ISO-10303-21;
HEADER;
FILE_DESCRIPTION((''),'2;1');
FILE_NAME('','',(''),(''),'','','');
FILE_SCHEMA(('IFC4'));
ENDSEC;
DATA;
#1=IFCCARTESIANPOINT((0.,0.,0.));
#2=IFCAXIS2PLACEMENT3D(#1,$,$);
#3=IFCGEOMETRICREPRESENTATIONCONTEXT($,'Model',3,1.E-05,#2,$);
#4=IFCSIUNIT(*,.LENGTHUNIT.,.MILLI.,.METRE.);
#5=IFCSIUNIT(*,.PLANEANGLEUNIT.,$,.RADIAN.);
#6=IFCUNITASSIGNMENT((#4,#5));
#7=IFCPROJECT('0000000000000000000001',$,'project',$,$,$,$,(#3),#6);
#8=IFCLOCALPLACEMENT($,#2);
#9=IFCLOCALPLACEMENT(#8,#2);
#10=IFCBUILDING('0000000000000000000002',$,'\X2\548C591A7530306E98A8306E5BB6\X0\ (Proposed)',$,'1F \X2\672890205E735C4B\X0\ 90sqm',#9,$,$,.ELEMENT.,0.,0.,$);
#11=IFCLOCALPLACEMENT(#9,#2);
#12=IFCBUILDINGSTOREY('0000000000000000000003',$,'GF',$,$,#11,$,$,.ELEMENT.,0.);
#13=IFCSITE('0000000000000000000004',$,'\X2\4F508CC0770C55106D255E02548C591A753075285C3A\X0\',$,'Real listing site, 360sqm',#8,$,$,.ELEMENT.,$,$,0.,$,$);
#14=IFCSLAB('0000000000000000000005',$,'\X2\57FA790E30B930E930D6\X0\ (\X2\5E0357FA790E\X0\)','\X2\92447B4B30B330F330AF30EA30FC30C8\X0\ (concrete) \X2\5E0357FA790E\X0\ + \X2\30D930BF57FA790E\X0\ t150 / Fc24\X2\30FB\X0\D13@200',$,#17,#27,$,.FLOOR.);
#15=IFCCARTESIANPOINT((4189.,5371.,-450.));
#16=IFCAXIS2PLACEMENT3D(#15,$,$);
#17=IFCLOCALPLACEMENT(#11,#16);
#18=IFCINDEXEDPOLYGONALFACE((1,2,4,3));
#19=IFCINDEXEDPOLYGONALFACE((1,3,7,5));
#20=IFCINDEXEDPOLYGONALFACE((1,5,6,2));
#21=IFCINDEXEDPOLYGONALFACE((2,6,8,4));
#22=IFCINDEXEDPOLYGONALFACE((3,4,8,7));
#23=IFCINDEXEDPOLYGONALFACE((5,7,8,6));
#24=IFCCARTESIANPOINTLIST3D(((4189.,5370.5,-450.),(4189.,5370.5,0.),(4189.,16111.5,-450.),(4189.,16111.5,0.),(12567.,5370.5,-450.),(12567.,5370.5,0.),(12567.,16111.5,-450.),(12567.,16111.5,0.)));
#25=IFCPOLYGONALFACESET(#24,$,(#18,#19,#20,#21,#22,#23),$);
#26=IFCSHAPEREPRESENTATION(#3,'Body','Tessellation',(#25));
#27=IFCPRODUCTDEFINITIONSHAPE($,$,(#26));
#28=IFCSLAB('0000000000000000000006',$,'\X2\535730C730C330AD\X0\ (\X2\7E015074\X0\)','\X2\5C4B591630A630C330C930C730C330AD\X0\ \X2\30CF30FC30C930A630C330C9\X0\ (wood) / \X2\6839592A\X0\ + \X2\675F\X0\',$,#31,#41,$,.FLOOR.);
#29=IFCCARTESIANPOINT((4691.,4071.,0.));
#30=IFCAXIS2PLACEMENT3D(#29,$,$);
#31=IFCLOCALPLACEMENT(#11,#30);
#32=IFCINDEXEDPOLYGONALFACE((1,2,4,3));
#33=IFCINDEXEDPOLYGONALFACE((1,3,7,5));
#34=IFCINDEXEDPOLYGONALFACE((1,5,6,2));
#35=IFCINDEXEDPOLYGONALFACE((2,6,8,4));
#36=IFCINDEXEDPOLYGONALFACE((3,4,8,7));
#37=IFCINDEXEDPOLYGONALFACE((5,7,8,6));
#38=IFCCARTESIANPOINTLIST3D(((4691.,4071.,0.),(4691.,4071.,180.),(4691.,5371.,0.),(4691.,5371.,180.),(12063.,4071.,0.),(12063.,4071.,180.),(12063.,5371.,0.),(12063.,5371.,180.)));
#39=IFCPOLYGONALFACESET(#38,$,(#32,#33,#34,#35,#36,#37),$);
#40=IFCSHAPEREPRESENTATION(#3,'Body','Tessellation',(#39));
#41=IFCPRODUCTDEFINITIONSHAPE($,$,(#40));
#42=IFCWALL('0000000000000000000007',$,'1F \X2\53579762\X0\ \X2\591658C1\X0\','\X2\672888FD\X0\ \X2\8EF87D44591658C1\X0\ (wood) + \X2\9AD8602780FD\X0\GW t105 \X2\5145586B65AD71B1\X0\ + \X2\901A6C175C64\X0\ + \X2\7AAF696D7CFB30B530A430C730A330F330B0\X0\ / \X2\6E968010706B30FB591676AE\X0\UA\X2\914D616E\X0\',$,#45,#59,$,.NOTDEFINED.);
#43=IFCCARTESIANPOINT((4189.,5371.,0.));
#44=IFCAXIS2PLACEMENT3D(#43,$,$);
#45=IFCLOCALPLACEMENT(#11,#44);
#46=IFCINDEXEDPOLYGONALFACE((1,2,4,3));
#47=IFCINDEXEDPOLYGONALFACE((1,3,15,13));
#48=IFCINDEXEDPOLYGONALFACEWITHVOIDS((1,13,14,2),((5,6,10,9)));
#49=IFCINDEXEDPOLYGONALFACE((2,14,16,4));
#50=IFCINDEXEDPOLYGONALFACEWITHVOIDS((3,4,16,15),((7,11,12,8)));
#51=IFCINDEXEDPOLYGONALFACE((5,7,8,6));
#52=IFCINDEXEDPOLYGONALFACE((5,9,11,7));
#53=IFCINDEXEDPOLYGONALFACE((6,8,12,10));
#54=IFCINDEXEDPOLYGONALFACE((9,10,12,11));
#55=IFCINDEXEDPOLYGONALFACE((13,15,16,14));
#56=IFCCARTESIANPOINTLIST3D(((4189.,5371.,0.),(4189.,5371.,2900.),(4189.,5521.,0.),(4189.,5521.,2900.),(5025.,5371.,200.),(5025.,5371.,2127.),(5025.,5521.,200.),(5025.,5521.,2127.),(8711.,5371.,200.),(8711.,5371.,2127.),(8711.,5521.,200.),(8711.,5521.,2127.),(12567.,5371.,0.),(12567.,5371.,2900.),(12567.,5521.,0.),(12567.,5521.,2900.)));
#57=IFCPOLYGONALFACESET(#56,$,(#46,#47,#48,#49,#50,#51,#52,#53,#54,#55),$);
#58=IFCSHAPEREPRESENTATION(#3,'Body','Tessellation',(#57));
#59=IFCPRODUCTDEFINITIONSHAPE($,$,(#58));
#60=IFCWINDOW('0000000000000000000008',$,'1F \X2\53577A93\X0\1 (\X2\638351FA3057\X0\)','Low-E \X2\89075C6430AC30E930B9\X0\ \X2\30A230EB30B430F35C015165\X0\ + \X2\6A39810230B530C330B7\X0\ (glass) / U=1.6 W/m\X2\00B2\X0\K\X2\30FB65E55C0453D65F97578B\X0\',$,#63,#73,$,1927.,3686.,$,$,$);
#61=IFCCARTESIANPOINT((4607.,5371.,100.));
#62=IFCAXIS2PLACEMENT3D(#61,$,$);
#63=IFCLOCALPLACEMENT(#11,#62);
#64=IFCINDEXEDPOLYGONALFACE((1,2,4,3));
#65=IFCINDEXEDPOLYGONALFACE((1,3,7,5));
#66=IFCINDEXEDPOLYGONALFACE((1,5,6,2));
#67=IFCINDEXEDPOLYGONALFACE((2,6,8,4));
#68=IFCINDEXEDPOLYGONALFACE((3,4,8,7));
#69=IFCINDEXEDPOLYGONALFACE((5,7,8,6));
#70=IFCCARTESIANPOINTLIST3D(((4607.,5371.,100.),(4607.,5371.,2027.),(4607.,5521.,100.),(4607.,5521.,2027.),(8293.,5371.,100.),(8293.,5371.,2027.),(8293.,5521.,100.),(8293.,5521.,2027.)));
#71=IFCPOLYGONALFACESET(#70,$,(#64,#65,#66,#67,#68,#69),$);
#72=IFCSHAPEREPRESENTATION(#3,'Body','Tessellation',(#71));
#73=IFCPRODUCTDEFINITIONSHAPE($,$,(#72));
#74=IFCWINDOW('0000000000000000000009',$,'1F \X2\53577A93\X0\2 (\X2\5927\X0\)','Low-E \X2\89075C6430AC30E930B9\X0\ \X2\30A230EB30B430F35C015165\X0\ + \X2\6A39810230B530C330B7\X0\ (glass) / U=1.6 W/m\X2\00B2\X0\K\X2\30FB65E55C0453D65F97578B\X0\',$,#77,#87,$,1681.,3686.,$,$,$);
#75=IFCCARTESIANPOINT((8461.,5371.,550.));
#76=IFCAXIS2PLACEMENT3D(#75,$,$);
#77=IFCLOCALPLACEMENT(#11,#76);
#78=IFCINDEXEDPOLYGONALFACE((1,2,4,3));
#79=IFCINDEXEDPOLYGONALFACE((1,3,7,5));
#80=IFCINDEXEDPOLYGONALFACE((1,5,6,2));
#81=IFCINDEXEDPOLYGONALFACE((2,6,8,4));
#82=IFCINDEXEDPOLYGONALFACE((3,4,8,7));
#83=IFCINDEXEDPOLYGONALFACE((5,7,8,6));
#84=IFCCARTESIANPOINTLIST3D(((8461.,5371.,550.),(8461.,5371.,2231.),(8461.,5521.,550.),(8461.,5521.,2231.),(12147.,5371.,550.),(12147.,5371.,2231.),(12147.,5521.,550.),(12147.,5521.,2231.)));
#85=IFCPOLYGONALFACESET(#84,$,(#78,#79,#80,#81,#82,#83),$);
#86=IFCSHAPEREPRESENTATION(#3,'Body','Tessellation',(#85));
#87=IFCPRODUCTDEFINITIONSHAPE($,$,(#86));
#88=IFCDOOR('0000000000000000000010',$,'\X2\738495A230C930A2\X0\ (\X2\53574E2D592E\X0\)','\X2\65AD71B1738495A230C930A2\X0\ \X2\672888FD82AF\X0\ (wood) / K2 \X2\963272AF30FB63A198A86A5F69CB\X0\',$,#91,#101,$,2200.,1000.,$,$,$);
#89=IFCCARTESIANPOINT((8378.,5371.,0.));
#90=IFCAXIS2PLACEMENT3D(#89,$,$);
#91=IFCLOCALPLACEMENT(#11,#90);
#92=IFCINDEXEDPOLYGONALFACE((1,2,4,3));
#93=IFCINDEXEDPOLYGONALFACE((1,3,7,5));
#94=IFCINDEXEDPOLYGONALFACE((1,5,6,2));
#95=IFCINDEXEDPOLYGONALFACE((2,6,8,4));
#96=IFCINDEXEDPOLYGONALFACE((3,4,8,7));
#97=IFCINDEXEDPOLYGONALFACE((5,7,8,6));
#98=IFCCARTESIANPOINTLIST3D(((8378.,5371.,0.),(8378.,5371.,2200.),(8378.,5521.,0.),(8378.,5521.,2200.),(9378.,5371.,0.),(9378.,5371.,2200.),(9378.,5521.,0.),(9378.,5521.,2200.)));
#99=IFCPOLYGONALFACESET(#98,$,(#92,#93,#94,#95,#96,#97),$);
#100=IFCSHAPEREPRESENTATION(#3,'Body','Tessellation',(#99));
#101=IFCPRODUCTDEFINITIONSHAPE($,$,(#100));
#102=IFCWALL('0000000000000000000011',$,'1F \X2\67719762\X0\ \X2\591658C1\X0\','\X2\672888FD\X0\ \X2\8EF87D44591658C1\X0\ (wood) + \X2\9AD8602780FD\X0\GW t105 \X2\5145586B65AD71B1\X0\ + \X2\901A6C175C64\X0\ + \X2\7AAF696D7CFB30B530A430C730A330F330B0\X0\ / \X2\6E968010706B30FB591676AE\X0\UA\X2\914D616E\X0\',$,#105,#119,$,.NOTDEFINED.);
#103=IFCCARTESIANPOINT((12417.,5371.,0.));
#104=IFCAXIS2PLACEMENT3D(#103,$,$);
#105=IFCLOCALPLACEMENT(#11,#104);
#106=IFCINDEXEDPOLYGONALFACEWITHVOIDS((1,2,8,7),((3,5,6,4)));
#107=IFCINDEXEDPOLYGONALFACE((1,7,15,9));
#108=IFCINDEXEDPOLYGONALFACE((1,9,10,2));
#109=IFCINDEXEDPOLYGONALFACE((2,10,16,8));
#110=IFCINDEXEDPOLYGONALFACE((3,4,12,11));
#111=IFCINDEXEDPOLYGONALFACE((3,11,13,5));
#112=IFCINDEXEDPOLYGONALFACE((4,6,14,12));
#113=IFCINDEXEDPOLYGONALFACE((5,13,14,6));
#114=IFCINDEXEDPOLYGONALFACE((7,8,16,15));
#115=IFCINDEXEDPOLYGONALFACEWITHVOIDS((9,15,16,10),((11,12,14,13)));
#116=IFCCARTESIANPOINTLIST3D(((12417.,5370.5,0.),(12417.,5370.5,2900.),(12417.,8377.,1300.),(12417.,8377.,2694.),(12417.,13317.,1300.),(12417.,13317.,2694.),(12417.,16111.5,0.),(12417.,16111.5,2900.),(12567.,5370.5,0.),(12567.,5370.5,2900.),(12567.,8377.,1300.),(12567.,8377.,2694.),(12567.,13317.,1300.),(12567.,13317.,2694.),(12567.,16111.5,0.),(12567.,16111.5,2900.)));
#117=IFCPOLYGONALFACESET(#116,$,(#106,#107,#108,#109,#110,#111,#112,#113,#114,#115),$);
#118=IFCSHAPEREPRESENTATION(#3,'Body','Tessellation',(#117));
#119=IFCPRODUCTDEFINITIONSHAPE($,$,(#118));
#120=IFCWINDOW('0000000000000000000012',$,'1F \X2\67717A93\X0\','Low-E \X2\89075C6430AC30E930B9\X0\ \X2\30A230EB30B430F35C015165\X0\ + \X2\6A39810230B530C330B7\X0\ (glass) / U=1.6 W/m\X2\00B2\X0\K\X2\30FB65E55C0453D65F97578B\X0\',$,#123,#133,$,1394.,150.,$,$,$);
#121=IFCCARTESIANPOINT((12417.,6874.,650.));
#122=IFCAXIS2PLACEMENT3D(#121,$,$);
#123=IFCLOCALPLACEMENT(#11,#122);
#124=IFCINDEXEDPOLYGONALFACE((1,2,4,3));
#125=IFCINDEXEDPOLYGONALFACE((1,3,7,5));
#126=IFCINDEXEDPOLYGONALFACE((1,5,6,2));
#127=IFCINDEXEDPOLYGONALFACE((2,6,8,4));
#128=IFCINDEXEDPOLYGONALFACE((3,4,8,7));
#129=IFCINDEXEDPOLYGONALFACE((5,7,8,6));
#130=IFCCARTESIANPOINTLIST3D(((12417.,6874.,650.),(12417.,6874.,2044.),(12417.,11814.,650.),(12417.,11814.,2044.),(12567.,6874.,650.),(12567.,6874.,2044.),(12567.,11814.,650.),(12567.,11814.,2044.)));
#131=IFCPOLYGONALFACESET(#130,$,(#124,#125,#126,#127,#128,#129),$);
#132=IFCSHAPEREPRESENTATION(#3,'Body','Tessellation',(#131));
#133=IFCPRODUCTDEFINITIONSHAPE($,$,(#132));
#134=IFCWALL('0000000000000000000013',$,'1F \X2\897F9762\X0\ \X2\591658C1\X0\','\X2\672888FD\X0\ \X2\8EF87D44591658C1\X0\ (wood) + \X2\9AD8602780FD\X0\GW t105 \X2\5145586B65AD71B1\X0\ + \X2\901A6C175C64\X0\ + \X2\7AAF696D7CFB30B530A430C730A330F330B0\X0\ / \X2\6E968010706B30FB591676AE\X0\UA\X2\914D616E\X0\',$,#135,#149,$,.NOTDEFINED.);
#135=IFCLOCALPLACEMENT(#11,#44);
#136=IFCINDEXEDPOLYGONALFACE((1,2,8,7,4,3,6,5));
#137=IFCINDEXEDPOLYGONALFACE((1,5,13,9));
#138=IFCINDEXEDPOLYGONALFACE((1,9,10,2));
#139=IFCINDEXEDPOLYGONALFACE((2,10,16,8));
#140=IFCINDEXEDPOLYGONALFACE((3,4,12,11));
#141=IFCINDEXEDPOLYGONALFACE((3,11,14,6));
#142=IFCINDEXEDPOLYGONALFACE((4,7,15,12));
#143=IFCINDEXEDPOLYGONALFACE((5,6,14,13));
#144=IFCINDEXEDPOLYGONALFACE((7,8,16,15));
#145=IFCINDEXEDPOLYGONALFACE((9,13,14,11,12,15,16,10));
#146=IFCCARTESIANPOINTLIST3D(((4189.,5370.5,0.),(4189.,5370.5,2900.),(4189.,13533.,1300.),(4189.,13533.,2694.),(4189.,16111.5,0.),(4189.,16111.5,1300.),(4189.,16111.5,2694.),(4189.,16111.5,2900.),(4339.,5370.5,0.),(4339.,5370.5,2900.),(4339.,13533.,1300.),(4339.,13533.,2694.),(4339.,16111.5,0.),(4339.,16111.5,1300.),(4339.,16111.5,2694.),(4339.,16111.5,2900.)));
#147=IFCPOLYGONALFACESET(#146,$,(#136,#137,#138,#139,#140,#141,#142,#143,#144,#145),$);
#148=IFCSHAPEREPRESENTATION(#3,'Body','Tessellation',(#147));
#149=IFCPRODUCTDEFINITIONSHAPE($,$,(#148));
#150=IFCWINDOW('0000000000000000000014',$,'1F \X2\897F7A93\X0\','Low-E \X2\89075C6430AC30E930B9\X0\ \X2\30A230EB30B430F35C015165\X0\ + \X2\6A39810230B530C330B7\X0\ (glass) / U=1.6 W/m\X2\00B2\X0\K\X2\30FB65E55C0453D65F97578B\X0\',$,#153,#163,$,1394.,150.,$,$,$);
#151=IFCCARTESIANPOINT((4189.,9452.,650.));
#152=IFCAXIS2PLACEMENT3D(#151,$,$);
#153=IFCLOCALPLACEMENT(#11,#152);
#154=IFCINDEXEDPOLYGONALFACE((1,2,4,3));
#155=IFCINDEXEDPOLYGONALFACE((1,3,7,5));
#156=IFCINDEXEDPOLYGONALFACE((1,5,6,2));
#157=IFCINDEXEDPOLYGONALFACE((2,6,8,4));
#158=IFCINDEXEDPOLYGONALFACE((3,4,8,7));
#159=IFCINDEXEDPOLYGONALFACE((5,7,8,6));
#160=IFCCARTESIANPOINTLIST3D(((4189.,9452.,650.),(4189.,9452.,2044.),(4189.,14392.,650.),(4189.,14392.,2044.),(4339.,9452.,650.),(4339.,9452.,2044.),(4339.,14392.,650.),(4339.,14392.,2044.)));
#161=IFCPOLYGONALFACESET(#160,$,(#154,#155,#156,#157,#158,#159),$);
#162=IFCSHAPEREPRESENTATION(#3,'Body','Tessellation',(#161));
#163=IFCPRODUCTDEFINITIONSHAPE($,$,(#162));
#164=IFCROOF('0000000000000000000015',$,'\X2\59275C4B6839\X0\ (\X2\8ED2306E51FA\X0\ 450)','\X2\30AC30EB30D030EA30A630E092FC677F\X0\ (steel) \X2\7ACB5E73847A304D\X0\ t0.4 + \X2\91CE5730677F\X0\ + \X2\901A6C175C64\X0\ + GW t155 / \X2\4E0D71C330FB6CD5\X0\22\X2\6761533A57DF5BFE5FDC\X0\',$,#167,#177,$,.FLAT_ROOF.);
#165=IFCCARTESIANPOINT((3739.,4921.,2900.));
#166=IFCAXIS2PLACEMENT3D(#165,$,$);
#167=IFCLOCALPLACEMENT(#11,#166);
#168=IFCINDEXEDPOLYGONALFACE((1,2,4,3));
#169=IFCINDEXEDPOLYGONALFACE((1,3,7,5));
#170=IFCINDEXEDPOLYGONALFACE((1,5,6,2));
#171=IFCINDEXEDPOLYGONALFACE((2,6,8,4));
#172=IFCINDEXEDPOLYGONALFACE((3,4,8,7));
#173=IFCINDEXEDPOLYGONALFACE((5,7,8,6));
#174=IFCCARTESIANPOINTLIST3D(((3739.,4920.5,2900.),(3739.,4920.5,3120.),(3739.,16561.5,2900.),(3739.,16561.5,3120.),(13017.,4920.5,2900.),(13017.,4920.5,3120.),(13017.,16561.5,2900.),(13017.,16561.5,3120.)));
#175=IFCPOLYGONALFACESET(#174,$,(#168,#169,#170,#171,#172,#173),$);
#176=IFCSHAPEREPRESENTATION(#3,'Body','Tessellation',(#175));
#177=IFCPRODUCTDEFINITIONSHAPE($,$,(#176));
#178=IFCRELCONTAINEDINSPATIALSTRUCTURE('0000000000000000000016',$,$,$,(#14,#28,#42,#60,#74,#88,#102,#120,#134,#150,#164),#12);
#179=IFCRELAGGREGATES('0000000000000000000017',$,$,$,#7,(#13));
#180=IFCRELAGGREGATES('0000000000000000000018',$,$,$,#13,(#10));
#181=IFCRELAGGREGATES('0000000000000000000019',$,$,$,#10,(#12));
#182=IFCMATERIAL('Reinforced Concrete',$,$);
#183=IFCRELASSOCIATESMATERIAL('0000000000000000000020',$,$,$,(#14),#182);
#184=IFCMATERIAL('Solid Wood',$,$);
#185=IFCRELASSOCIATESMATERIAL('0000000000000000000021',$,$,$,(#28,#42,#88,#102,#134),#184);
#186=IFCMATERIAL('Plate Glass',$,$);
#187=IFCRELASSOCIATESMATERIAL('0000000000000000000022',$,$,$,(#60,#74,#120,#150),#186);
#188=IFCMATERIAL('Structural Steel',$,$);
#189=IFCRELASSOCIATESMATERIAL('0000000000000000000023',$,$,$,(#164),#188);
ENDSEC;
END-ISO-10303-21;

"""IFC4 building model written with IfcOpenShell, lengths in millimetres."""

from ifc_helpers import new_model, si_unit, frame, frame_2d, origin, place, context, project, spatial, rectangle, extrude, material, element, fill, save


model = new_model("IFC4")

# Units and contexts
model_context = context("Model", 3, precision=1e-05, world=origin())
ifc_project = project(units=[si_unit("LENGTHUNIT", "METRE", prefix="MILLI"), si_unit("PLANEANGLEUNIT", "RADIAN")], contexts=[model_context])

# Site, building, storey
site_placement = place(None, origin())
site = spatial("IfcSite", under=ifc_project, at=site_placement, Name="佐賀県唐津市和多田用尺", ObjectType="Real listing site, 360sqm", CompositionType="ELEMENT", RefElevation=0.0)
building_placement = place(site_placement, origin())
building = spatial("IfcBuilding", under=site, at=building_placement, Name="和多田の風の家 (Proposed)", ObjectType="1F 木造平屋 90sqm", CompositionType="ELEMENT", ElevationOfRefHeight=0.0, ElevationOfTerrain=0.0)
storey_placement = place(building_placement, origin())
storey = spatial("IfcBuildingStorey", under=building, at=storey_placement, Name="GF", CompositionType="ELEMENT", Elevation=0.0)

# Slabs
ifc_material_1 = material(Name="Reinforced Concrete")
slab_1_placement = place(storey_placement, frame((4189.0, 5371.0, -450.0)))
element("IfcSlab", 1, at=slab_1_placement, inside=storey, material=ifc_material_1, Name="基礎スラブ (布基礎)", Description="鉄筋コンクリート (concrete) 布基礎 + ベタ基礎 t150 / Fc24・D13@200", PredefinedType="FLOOR", context=model_context, shape_type="SweptSolid", body=[
    extrude(rectangle(XDim=8378.0, YDim=10741.0, at=frame_2d((4189.0, 5370.0))), frame((4189.0, 5371.0, -450.0)), (0.0, 0.0, 1.0), 450.0),
])
ifc_material_2 = material(Name="Solid Wood")
slab_2_placement = place(storey_placement, frame((4691.0, 4071.0, 0.0)))
element("IfcSlab", 2, at=slab_2_placement, inside=storey, material=ifc_material_2, Name="南デッキ (縁側)", Description="屋外ウッドデッキ ハードウッド (wood) / 根太 + 束", PredefinedType="FLOOR", context=model_context, shape_type="SweptSolid", body=[
    extrude(rectangle(XDim=7372.0, YDim=1300.0, at=frame_2d((3686.0, 650.0))), frame((4691.0, 4071.0, 0.0)), (0.0, 0.0, 1.0), 180.0),
])

# Wall, openings, windows, door
wall_1_placement = place(storey_placement, frame((4189.0, 5371.0, 0.0)))
wall_1 = element("IfcWall", 3, at=wall_1_placement, inside=storey, material=ifc_material_2, Name="1F 南面 外壁", Description="木製 軸組外壁 (wood) + 高性能GW t105 充填断熱 + 通気層 + 窯業系サイディング / 準耐火・外皮UA配慮", PredefinedType="NOTDEFINED", context=model_context, shape_type="SweptSolid", body=[
    extrude(rectangle(XDim=8378.0, YDim=150.0, at=frame_2d((4189.0, 75.0))), frame((4189.0, 5371.0, 0.0)), (0.0, 0.0, 1.0), 2900.0),
])
opening_1_placement = place(storey_placement, frame((4607.0, 5371.0, 100.0)))
opening_1 = element("IfcOpeningElement", 4, at=opening_1_placement, cuts=wall_1, PredefinedType="NOTDEFINED", context=model_context, shape_type="SweptSolid", body=[
    extrude(rectangle(XDim=3686.0, YDim=150.0, at=frame_2d((1843.0, 75.0))), frame((4607.0, 5371.0, 100.0)), (0.0, 0.0, 1.0), 1927.0),
])
opening_2_placement = place(storey_placement, frame((8461.0, 5371.0, 550.0)))
opening_2 = element("IfcOpeningElement", 5, at=opening_2_placement, cuts=wall_1, PredefinedType="NOTDEFINED", context=model_context, shape_type="SweptSolid", body=[
    extrude(rectangle(XDim=3686.0, YDim=150.0, at=frame_2d((1843.0, 75.0))), frame((8461.0, 5371.0, 550.0)), (0.0, 0.0, 1.0), 1681.0),
])
opening_3_placement = place(storey_placement, frame((8378.0, 5371.0, 0.0)))
opening_3 = element("IfcOpeningElement", 6, at=opening_3_placement, cuts=wall_1, PredefinedType="NOTDEFINED", context=model_context, shape_type="SweptSolid", body=[
    extrude(rectangle(XDim=1000.0, YDim=150.0, at=frame_2d((500.0, 75.0))), frame((8378.0, 5371.0, 0.0)), (0.0, 0.0, 1.0), 2200.0),
])
ifc_material_3 = material(Name="Plate Glass")
window_1_placement = place(storey_placement, frame((4607.0, 5371.0, 100.0)))
window_1 = element("IfcWindow", 7, at=window_1_placement, inside=storey, material=ifc_material_3, Name="1F 南窓1 (掃出し)", Description="Low-E 複層ガラス アルゴン封入 + 樹脂サッシ (glass) / U=1.6 W/m²K・日射取得型", OverallHeight=1927.0, OverallWidth=3686.0, context=model_context, shape_type="SweptSolid", body=[
    extrude(rectangle(XDim=3686.0, YDim=150.0, at=frame_2d((1843.0, 75.0))), frame((4607.0, 5371.0, 100.0)), (0.0, 0.0, 1.0), 1927.0),
])
fill(opening_1, window_1)
window_2_placement = place(storey_placement, frame((8461.0, 5371.0, 550.0)))
window_2 = element("IfcWindow", 8, at=window_2_placement, inside=storey, material=ifc_material_3, Name="1F 南窓2 (大)", Description="Low-E 複層ガラス アルゴン封入 + 樹脂サッシ (glass) / U=1.6 W/m²K・日射取得型", OverallHeight=1681.0, OverallWidth=3686.0, context=model_context, shape_type="SweptSolid", body=[
    extrude(rectangle(XDim=3686.0, YDim=150.0, at=frame_2d((1843.0, 75.0))), frame((8461.0, 5371.0, 550.0)), (0.0, 0.0, 1.0), 1681.0),
])
fill(opening_2, window_2)
door_placement = place(storey_placement, frame((8378.0, 5371.0, 0.0)))
door = element("IfcDoor", 9, at=door_placement, inside=storey, material=ifc_material_2, Name="玄関ドア (南中央)", Description="断熱玄関ドア 木製芯 (wood) / K2 防犯・採風機構", OverallHeight=2200.0, OverallWidth=1000.0, context=model_context, shape_type="SweptSolid", body=[
    extrude(rectangle(XDim=1000.0, YDim=150.0, at=frame_2d((500.0, 75.0))), frame((8378.0, 5371.0, 0.0)), (0.0, 0.0, 1.0), 2200.0),
])
fill(opening_3, door)

# Walls, openings, windows
wall_2_placement = place(storey_placement, frame((12417.0, 5371.0, 0.0)))
wall_2 = element("IfcWall", 10, at=wall_2_placement, inside=storey, material=ifc_material_2, Name="1F 東面 外壁", Description="木製 軸組外壁 (wood) + 高性能GW t105 充填断熱 + 通気層 + 窯業系サイディング / 準耐火・外皮UA配慮", PredefinedType="NOTDEFINED", context=model_context, shape_type="SweptSolid", body=[
    extrude(rectangle(XDim=150.0, YDim=10741.0, at=frame_2d((75.0, 5370.0))), frame((12417.0, 5371.0, 0.0)), (0.0, 0.0, 1.0), 2900.0),
])
opening_4_placement = place(storey_placement, frame((12417.0, 6874.0, 650.0)))
opening_4 = element("IfcOpeningElement", 11, at=opening_4_placement, cuts=wall_2, PredefinedType="NOTDEFINED", context=model_context, shape_type="SweptSolid", body=[
    extrude(rectangle(XDim=150.0, YDim=4940.0, at=frame_2d((75.0, 2470.0))), frame((12417.0, 6874.0, 650.0)), (0.0, 0.0, 1.0), 1394.0),
])
window_3_placement = place(storey_placement, frame((12417.0, 6874.0, 650.0)))
window_3 = element("IfcWindow", 12, at=window_3_placement, inside=storey, material=ifc_material_3, Name="1F 東窓", Description="Low-E 複層ガラス アルゴン封入 + 樹脂サッシ (glass) / U=1.6 W/m²K・日射取得型", OverallHeight=1394.0, OverallWidth=150.0, context=model_context, shape_type="SweptSolid", body=[
    extrude(rectangle(XDim=150.0, YDim=4940.0, at=frame_2d((75.0, 2470.0))), frame((12417.0, 6874.0, 650.0)), (0.0, 0.0, 1.0), 1394.0),
])
fill(opening_4, window_3)
wall_3_placement = place(storey_placement, frame((4189.0, 5371.0, 0.0)))
wall_3 = element("IfcWall", 13, at=wall_3_placement, inside=storey, material=ifc_material_2, Name="1F 西面 外壁", Description="木製 軸組外壁 (wood) + 高性能GW t105 充填断熱 + 通気層 + 窯業系サイディング / 準耐火・外皮UA配慮", PredefinedType="NOTDEFINED", context=model_context, shape_type="SweptSolid", body=[
    extrude(rectangle(XDim=150.0, YDim=10741.0, at=frame_2d((75.0, 5370.0))), frame((4189.0, 5371.0, 0.0)), (0.0, 0.0, 1.0), 2900.0),
])
opening_5_placement = place(storey_placement, frame((4189.0, 9452.0, 650.0)))
opening_5 = element("IfcOpeningElement", 14, at=opening_5_placement, cuts=wall_3, PredefinedType="NOTDEFINED", context=model_context, shape_type="SweptSolid", body=[
    extrude(rectangle(XDim=150.0, YDim=4940.0, at=frame_2d((75.0, 2470.0))), frame((4189.0, 9452.0, 650.0)), (0.0, 0.0, 1.0), 1394.0),
])
window_4_placement = place(storey_placement, frame((4189.0, 9452.0, 650.0)))
window_4 = element("IfcWindow", 15, at=window_4_placement, inside=storey, material=ifc_material_3, Name="1F 西窓", Description="Low-E 複層ガラス アルゴン封入 + 樹脂サッシ (glass) / U=1.6 W/m²K・日射取得型", OverallHeight=1394.0, OverallWidth=150.0, context=model_context, shape_type="SweptSolid", body=[
    extrude(rectangle(XDim=150.0, YDim=4940.0, at=frame_2d((75.0, 2470.0))), frame((4189.0, 9452.0, 650.0)), (0.0, 0.0, 1.0), 1394.0),
])
fill(opening_5, window_4)

# Roof
ifc_material_4 = material(Name="Structural Steel")
roof_placement = place(storey_placement, frame((3739.0, 4921.0, 2900.0)))
element("IfcRoof", 16, at=roof_placement, inside=storey, material=ifc_material_4, Name="大屋根 (軒の出 450)", Description="ガルバリウム鋼板 (steel) 立平葺き t0.4 + 野地板 + 通気層 + GW t155 / 不燃・法22条区域対応", PredefinedType="FLAT_ROOF", context=model_context, shape_type="SweptSolid", body=[
    extrude(rectangle(XDim=9278.0, YDim=11641.0, at=frame_2d((4639.0, 5820.0))), frame((3739.0, 4921.0, 2900.0)), (0.0, 0.0, 1.0), 220.0),
])

save(model, "model.ifc")
